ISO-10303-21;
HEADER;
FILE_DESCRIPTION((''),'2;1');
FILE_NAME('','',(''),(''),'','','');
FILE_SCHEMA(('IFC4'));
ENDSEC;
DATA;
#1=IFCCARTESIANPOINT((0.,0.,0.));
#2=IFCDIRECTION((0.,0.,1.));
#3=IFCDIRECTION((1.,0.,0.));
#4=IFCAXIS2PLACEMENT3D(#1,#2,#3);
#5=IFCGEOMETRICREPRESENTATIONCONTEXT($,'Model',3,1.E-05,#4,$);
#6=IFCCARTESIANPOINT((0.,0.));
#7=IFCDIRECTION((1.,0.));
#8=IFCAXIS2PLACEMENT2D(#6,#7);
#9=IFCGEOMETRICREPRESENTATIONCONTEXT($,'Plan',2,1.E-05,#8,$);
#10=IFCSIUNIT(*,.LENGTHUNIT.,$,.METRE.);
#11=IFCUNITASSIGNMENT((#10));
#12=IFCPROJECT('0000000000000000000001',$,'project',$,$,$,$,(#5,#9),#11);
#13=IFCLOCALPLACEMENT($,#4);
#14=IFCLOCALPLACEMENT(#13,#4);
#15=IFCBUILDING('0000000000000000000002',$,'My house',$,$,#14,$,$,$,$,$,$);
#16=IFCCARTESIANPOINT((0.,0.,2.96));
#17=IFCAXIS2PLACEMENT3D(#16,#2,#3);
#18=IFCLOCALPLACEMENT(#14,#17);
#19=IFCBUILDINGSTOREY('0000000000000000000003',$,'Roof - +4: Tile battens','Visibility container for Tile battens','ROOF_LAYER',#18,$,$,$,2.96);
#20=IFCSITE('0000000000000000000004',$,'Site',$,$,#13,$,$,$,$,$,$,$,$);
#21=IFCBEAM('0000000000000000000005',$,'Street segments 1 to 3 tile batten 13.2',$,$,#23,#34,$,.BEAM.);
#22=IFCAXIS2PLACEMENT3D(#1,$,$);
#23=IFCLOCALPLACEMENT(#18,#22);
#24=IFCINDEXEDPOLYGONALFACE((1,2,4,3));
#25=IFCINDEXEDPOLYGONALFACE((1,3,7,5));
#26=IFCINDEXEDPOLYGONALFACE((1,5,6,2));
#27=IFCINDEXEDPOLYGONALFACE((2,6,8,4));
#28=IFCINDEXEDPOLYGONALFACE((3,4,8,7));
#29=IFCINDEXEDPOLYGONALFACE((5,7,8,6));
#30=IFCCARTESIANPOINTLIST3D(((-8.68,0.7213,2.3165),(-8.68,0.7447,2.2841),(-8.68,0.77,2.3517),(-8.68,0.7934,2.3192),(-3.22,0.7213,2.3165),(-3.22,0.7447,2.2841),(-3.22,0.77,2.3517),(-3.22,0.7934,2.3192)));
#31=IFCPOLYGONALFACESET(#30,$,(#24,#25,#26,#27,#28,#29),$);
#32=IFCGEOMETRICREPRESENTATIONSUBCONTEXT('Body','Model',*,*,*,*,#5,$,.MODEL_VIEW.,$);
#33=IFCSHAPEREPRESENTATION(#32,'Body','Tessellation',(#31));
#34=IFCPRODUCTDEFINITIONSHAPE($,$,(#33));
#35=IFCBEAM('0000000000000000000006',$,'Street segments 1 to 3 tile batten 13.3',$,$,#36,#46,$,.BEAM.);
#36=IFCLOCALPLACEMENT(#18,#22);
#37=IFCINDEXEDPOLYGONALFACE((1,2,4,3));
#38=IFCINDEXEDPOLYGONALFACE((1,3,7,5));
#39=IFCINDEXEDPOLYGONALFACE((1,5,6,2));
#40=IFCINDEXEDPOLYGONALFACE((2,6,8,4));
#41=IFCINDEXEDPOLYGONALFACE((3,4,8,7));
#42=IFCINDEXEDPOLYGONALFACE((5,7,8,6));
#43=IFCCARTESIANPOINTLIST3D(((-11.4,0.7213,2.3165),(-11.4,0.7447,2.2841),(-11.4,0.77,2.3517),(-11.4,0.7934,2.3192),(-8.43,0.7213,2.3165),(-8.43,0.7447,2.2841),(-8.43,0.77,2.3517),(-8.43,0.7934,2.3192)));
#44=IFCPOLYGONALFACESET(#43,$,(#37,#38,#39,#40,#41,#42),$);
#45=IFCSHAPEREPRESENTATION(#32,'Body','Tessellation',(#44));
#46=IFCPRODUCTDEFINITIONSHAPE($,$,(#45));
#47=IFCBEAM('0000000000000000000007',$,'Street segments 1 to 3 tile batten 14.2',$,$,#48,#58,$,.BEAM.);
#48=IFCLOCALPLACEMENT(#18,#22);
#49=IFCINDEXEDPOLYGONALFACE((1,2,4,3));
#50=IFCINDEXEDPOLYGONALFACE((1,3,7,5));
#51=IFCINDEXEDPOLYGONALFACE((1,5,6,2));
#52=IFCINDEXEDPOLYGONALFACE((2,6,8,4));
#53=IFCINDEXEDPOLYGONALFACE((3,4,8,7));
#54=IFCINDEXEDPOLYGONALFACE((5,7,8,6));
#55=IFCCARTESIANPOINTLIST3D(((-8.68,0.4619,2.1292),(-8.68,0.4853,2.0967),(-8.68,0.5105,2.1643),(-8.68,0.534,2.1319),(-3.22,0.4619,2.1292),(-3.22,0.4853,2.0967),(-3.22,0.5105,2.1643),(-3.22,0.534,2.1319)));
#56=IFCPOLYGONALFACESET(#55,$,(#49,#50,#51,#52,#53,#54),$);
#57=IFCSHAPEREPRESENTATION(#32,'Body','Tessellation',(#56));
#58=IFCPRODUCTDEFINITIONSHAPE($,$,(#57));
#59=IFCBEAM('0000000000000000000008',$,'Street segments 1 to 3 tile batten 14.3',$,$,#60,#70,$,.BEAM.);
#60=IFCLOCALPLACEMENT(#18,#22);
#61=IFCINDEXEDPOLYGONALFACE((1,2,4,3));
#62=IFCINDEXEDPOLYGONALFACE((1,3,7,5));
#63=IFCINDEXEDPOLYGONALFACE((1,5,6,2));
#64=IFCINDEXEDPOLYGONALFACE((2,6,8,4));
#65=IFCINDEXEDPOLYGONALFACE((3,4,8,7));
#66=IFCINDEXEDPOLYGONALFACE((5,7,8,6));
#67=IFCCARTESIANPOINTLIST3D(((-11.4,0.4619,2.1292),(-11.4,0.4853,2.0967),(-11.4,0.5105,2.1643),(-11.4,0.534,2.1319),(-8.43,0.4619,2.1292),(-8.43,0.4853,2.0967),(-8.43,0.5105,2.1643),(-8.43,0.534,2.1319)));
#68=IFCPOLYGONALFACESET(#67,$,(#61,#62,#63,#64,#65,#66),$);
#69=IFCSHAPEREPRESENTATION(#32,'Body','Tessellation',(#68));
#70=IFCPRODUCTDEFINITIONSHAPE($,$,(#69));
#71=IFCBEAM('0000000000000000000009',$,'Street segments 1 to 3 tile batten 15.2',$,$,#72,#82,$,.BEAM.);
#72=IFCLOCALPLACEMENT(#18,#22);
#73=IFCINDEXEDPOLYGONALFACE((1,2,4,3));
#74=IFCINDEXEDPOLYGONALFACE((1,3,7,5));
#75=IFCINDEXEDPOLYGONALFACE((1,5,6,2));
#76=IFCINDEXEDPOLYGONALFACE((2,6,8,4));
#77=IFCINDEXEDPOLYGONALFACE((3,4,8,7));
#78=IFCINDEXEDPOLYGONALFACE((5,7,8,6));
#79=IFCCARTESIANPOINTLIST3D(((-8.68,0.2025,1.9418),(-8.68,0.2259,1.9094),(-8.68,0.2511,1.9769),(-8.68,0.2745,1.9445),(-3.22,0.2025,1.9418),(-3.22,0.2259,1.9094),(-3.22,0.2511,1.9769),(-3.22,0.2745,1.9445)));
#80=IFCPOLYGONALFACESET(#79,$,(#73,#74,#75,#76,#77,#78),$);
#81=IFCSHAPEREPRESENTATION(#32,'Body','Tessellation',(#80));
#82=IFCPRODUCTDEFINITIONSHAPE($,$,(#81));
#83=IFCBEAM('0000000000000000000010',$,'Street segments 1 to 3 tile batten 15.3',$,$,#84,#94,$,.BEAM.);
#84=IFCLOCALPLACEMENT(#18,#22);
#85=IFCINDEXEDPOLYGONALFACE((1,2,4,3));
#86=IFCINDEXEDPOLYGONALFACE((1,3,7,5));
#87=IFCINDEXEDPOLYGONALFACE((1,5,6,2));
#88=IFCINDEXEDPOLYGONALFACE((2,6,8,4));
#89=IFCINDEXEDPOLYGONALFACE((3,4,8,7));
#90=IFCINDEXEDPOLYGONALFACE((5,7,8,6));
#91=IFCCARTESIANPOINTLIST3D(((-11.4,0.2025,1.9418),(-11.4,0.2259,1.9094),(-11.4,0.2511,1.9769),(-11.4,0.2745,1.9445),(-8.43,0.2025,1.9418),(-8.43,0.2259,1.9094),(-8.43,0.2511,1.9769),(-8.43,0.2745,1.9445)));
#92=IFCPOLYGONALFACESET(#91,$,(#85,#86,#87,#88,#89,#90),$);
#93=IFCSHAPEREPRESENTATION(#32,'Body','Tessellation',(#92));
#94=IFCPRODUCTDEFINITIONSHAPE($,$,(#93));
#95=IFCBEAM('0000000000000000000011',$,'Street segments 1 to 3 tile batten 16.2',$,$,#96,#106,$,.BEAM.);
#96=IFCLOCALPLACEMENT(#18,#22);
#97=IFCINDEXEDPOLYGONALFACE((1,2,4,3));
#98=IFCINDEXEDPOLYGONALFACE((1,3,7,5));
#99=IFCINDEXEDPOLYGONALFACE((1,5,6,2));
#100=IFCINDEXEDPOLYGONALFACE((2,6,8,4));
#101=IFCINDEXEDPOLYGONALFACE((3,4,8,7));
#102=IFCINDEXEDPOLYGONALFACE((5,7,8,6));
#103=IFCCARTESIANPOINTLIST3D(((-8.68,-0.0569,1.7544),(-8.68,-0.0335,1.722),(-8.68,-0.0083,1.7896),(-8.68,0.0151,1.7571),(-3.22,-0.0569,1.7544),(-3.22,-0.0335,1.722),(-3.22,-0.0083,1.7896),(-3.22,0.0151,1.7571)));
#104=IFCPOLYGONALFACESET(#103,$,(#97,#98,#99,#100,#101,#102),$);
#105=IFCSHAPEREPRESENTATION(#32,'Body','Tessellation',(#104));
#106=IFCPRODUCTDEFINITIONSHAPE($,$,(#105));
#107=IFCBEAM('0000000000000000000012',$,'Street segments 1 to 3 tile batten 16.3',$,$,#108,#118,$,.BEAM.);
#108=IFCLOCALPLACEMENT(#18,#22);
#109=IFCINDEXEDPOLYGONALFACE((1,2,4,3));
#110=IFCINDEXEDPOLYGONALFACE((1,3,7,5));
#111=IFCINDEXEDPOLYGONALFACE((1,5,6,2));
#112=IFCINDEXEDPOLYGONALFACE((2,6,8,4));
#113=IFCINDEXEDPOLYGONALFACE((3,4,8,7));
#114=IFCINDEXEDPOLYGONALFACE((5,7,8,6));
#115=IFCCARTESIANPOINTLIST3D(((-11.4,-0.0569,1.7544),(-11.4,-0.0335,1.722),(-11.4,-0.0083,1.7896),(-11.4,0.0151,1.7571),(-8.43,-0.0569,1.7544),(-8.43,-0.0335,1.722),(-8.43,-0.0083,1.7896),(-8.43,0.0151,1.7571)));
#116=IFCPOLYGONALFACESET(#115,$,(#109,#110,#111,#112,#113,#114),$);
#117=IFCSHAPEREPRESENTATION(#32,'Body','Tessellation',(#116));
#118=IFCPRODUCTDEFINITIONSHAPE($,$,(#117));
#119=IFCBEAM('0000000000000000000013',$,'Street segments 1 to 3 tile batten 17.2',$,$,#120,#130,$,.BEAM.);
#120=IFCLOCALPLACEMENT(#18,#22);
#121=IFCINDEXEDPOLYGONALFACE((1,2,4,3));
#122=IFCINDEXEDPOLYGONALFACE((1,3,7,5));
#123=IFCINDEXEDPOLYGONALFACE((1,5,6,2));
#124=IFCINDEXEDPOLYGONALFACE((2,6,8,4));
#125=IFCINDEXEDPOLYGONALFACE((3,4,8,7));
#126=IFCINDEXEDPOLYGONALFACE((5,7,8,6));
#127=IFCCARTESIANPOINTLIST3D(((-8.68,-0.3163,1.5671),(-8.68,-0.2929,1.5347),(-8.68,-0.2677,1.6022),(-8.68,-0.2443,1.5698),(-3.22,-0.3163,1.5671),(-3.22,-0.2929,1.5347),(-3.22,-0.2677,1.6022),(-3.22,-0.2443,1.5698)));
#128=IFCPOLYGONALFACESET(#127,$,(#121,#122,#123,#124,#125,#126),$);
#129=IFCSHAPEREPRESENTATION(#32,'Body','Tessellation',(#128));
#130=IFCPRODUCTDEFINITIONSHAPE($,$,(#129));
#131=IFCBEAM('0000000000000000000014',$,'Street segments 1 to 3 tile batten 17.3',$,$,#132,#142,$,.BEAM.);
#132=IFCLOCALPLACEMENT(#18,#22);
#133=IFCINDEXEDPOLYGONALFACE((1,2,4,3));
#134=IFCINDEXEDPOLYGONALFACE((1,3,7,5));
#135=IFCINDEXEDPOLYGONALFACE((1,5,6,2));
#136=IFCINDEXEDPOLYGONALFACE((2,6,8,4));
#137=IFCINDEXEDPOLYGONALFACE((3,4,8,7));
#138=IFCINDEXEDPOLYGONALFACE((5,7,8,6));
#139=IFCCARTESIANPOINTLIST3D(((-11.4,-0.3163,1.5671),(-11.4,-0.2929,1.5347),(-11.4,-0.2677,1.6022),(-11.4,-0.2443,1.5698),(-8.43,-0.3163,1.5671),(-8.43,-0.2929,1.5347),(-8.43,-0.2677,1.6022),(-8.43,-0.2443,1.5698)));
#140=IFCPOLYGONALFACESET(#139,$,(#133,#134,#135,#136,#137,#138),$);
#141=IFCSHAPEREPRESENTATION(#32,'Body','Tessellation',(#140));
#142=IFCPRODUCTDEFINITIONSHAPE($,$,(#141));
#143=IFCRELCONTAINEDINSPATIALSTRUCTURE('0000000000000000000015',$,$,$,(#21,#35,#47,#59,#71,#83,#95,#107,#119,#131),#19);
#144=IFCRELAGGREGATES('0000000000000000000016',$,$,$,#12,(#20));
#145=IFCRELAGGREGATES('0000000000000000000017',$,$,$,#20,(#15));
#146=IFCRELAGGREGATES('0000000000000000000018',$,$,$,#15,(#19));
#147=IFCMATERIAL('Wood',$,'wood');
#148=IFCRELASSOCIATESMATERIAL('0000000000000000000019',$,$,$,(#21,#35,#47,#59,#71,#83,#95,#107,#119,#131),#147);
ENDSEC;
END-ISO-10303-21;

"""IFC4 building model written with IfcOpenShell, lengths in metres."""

from ifc_helpers import new_model, si_unit, frame, origin_with_axes, origin_2d_with_axis, place, context, subcontext, project, spatial, rectangle, extrude, clip, halfspace, source, transform, mapped, material, element, save


model = new_model("IFC4")

# Units and contexts
model_context = context("Model", 3, precision=1e-05, world=origin_with_axes())
plan_context = context("Plan", 2, precision=1e-05, world=origin_2d_with_axis())
body_context = subcontext(model_context, "Body", "Model", "MODEL_VIEW")
ifc_project = project(units=[si_unit("LENGTHUNIT", "METRE")], contexts=[model_context, plan_context])

# Site, building, storey
site_placement = place(None, origin_with_axes())
site = spatial("IfcSite", under=ifc_project, at=site_placement, Name="Site")
building_placement = place(site_placement, origin_with_axes())
building = spatial("IfcBuilding", under=site, at=building_placement, Name="My house")
storey_placement = place(building_placement, frame((0.0, 0.0, 2.96), z_axis=(0.0, 0.0, 1.0), x_axis=(1.0, 0.0, 0.0)))
storey = spatial("IfcBuildingStorey", under=building, at=storey_placement, Name="Roof - +4: Tile battens", Description="Visibility container for Tile battens", ObjectType="ROOF_LAYER", Elevation=2.96)

# Beams
ifc_material = material(Name="Wood", Category="wood")
shared_shape_1 = source(origin_with_axes(), body_context, "Body", "Clipping", [
    clip(clip(extrude(rectangle(XDim=0.06, YDim=0.04), frame((0.0, 0.0, 0.0), z_axis=(1.0, 0.0, 0.0), x_axis=(0.0, 1.0, 0.0)), (0.0, 0.0, 1.0), 5.46), halfspace(frame((-3.22, -0.4616, -6.1772), z_axis=(0.0, 0.810664, -0.585512), x_axis=(1.0, 0.0, 0.0)), False)), halfspace(frame((-3.22, -4.3122, -3.396), z_axis=(0.0, -0.810664, 0.585512), x_axis=(-1.0, 0.0, 0.0)), False)),
])
beam_1_placement = place(storey_placement, frame((-3.22, 0.7573, 2.3179), z_axis=(0.0, -0.585512, 0.810664), x_axis=(1.0, 0.0, 0.0)))
element("IfcBeam", 1, at=beam_1_placement, inside=storey, material=ifc_material, Name="Street segments 1 to 3 tile batten 13.2", PredefinedType="BEAM", context=body_context, shape_type="MappedRepresentation", body=[
    mapped(shared_shape_1, transform((0.0, 0.0, 0.0), x_axis=(-1.0, 0.0, 0.0), y_axis=(0.0, 1.0, 0.0), z_axis=(0.0, 0.0, 1.0), scale=1.0)),
])
shared_shape_2 = source(origin_with_axes(), body_context, "Body", "Clipping", [
    clip(clip(extrude(rectangle(XDim=0.06, YDim=0.04), frame((0.0, 0.0, 0.0), z_axis=(1.0, 0.0, 0.0), x_axis=(0.0, 1.0, 0.0)), (0.0, 0.0, 1.0), 2.97), halfspace(frame((-8.43, -0.4616, -6.1772), z_axis=(0.0, 0.810664, -0.585512), x_axis=(1.0, 0.0, 0.0)), False)), halfspace(frame((-8.43, -4.3122, -3.396), z_axis=(0.0, -0.810664, 0.585512), x_axis=(-1.0, 0.0, 0.0)), False)),
])
beam_2_placement = place(storey_placement, frame((-8.43, 0.7573, 2.3179), z_axis=(0.0, -0.585512, 0.810664), x_axis=(1.0, 0.0, 0.0)))
element("IfcBeam", 2, at=beam_2_placement, inside=storey, material=ifc_material, Name="Street segments 1 to 3 tile batten 13.3", PredefinedType="BEAM", context=body_context, shape_type="MappedRepresentation", body=[
    mapped(shared_shape_2, transform((0.0, 0.0, 0.0), x_axis=(-1.0, 0.0, 0.0), y_axis=(0.0, 1.0, 0.0), z_axis=(0.0, 0.0, 1.0), scale=1.0)),
])
shared_shape_3 = source(origin_with_axes(), body_context, "Body", "Clipping", [
    clip(clip(extrude(rectangle(XDim=0.06, YDim=0.04), frame((0.0, 0.0, 0.0), z_axis=(1.0, 0.0, 0.0), x_axis=(0.0, 1.0, 0.0)), (0.0, 0.0, 1.0), 5.46), halfspace(frame((-3.22, -0.1416, -6.1772), z_axis=(0.0, 0.810664, -0.585512), x_axis=(1.0, 0.0, 0.0)), False)), halfspace(frame((-3.22, -3.9922, -3.396), z_axis=(0.0, -0.810664, 0.585512), x_axis=(-1.0, 0.0, 0.0)), False)),
])
beam_3_placement = place(storey_placement, frame((-3.22, 0.4979, 2.1305), z_axis=(0.0, -0.585512, 0.810664), x_axis=(1.0, 0.0, 0.0)))
element("IfcBeam", 3, at=beam_3_placement, inside=storey, material=ifc_material, Name="Street segments 1 to 3 tile batten 14.2", PredefinedType="BEAM", context=body_context, shape_type="MappedRepresentation", body=[
    mapped(shared_shape_3, transform((0.0, 0.0, 0.0), x_axis=(-1.0, 0.0, 0.0), y_axis=(0.0, 1.0, 0.0), z_axis=(0.0, 0.0, 1.0), scale=1.0)),
])
shared_shape_4 = source(origin_with_axes(), body_context, "Body", "Clipping", [
    clip(clip(extrude(rectangle(XDim=0.06, YDim=0.04), frame((0.0, 0.0, 0.0), z_axis=(1.0, 0.0, 0.0), x_axis=(0.0, 1.0, 0.0)), (0.0, 0.0, 1.0), 2.97), halfspace(frame((-8.43, -0.1416, -6.1772), z_axis=(0.0, 0.810664, -0.585512), x_axis=(1.0, 0.0, 0.0)), False)), halfspace(frame((-8.43, -3.9922, -3.396), z_axis=(0.0, -0.810664, 0.585512), x_axis=(-1.0, 0.0, 0.0)), False)),
])
beam_4_placement = place(storey_placement, frame((-8.43, 0.4979, 2.1305), z_axis=(0.0, -0.585512, 0.810664), x_axis=(1.0, 0.0, 0.0)))
element("IfcBeam", 4, at=beam_4_placement, inside=storey, material=ifc_material, Name="Street segments 1 to 3 tile batten 14.3", PredefinedType="BEAM", context=body_context, shape_type="MappedRepresentation", body=[
    mapped(shared_shape_4, transform((0.0, 0.0, 0.0), x_axis=(-1.0, 0.0, 0.0), y_axis=(0.0, 1.0, 0.0), z_axis=(0.0, 0.0, 1.0), scale=1.0)),
])
shared_shape_5 = source(origin_with_axes(), body_context, "Body", "Clipping", [
    clip(clip(extrude(rectangle(XDim=0.06, YDim=0.04), frame((0.0, 0.0, 0.0), z_axis=(1.0, 0.0, 0.0), x_axis=(0.0, 1.0, 0.0)), (0.0, 0.0, 1.0), 5.46), halfspace(frame((-3.22, 0.1784, -6.1772), z_axis=(0.0, 0.810664, -0.585512), x_axis=(1.0, 0.0, 0.0)), False)), halfspace(frame((-3.22, -3.6722, -3.396), z_axis=(0.0, -0.810664, 0.585512), x_axis=(-1.0, 0.0, 0.0)), False)),
])
beam_5_placement = place(storey_placement, frame((-3.22, 0.2385, 1.9432), z_axis=(0.0, -0.585512, 0.810664), x_axis=(1.0, 0.0, 0.0)))
element("IfcBeam", 5, at=beam_5_placement, inside=storey, material=ifc_material, Name="Street segments 1 to 3 tile batten 15.2", PredefinedType="BEAM", context=body_context, shape_type="MappedRepresentation", body=[
    mapped(shared_shape_5, transform((0.0, 0.0, 0.0), x_axis=(-1.0, 0.0, 0.0), y_axis=(0.0, 1.0, 0.0), z_axis=(0.0, 0.0, 1.0), scale=1.0)),
])
shared_shape_6 = source(origin_with_axes(), body_context, "Body", "Clipping", [
    clip(clip(extrude(rectangle(XDim=0.06, YDim=0.04), frame((0.0, 0.0, 0.0), z_axis=(1.0, 0.0, 0.0), x_axis=(0.0, 1.0, 0.0)), (0.0, 0.0, 1.0), 2.97), halfspace(frame((-8.43, 0.1784, -6.1772), z_axis=(0.0, 0.810664, -0.585512), x_axis=(1.0, 0.0, 0.0)), False)), halfspace(frame((-8.43, -3.6722, -3.396), z_axis=(0.0, -0.810664, 0.585512), x_axis=(-1.0, 0.0, 0.0)), False)),
])
beam_6_placement = place(storey_placement, frame((-8.43, 0.2385, 1.9432), z_axis=(0.0, -0.585512, 0.810664), x_axis=(1.0, 0.0, 0.0)))
element("IfcBeam", 6, at=beam_6_placement, inside=storey, material=ifc_material, Name="Street segments 1 to 3 tile batten 15.3", PredefinedType="BEAM", context=body_context, shape_type="MappedRepresentation", body=[
    mapped(shared_shape_6, transform((0.0, 0.0, 0.0), x_axis=(-1.0, 0.0, 0.0), y_axis=(0.0, 1.0, 0.0), z_axis=(0.0, 0.0, 1.0), scale=1.0)),
])
shared_shape_7 = source(origin_with_axes(), body_context, "Body", "Clipping", [
    clip(clip(extrude(rectangle(XDim=0.06, YDim=0.04), frame((0.0, 0.0, 0.0), z_axis=(1.0, 0.0, 0.0), x_axis=(0.0, 1.0, 0.0)), (0.0, 0.0, 1.0), 5.46), halfspace(frame((-3.22, 0.4984, -6.1772), z_axis=(0.0, 0.810664, -0.585512), x_axis=(1.0, 0.0, 0.0)), False)), halfspace(frame((-3.22, -3.3522, -3.396), z_axis=(0.0, -0.810664, 0.585512), x_axis=(-1.0, 0.0, 0.0)), False)),
])
beam_7_placement = place(storey_placement, frame((-3.22, -0.0209, 1.7558), z_axis=(0.0, -0.585512, 0.810664), x_axis=(1.0, 0.0, 0.0)))
element("IfcBeam", 7, at=beam_7_placement, inside=storey, material=ifc_material, Name="Street segments 1 to 3 tile batten 16.2", PredefinedType="BEAM", context=body_context, shape_type="MappedRepresentation", body=[
    mapped(shared_shape_7, transform((0.0, 0.0, 0.0), x_axis=(-1.0, 0.0, 0.0), y_axis=(0.0, 1.0, 0.0), z_axis=(0.0, 0.0, 1.0), scale=1.0)),
])
shared_shape_8 = source(origin_with_axes(), body_context, "Body", "Clipping", [
    clip(clip(extrude(rectangle(XDim=0.06, YDim=0.04), frame((0.0, 0.0, 0.0), z_axis=(1.0, 0.0, 0.0), x_axis=(0.0, 1.0, 0.0)), (0.0, 0.0, 1.0), 2.97), halfspace(frame((-8.43, 0.4984, -6.1772), z_axis=(0.0, 0.810664, -0.585512), x_axis=(1.0, 0.0, 0.0)), False)), halfspace(frame((-8.43, -3.3522, -3.396), z_axis=(0.0, -0.810664, 0.585512), x_axis=(-1.0, 0.0, 0.0)), False)),
])
beam_8_placement = place(storey_placement, frame((-8.43, -0.0209, 1.7558), z_axis=(0.0, -0.585512, 0.810664), x_axis=(1.0, 0.0, 0.0)))
element("IfcBeam", 8, at=beam_8_placement, inside=storey, material=ifc_material, Name="Street segments 1 to 3 tile batten 16.3", PredefinedType="BEAM", context=body_context, shape_type="MappedRepresentation", body=[
    mapped(shared_shape_8, transform((0.0, 0.0, 0.0), x_axis=(-1.0, 0.0, 0.0), y_axis=(0.0, 1.0, 0.0), z_axis=(0.0, 0.0, 1.0), scale=1.0)),
])
shared_shape_9 = source(origin_with_axes(), body_context, "Body", "Clipping", [
    clip(clip(extrude(rectangle(XDim=0.06, YDim=0.04), frame((0.0, 0.0, 0.0), z_axis=(1.0, 0.0, 0.0), x_axis=(0.0, 1.0, 0.0)), (0.0, 0.0, 1.0), 5.46), halfspace(frame((-3.22, 0.8184, -6.1772), z_axis=(0.0, 0.810664, -0.585512), x_axis=(1.0, 0.0, 0.0)), False)), halfspace(frame((-3.22, -3.0322, -3.396), z_axis=(0.0, -0.810664, 0.585512), x_axis=(-1.0, 0.0, 0.0)), False)),
])
beam_9_placement = place(storey_placement, frame((-3.22, -0.2803, 1.5684), z_axis=(0.0, -0.585512, 0.810664), x_axis=(1.0, 0.0, 0.0)))
element("IfcBeam", 9, at=beam_9_placement, inside=storey, material=ifc_material, Name="Street segments 1 to 3 tile batten 17.2", PredefinedType="BEAM", context=body_context, shape_type="MappedRepresentation", body=[
    mapped(shared_shape_9, transform((0.0, 0.0, 0.0), x_axis=(-1.0, 0.0, 0.0), y_axis=(0.0, 1.0, 0.0), z_axis=(0.0, 0.0, 1.0), scale=1.0)),
])
shared_shape_10 = source(origin_with_axes(), body_context, "Body", "Clipping", [
    clip(clip(extrude(rectangle(XDim=0.06, YDim=0.04), frame((0.0, 0.0, 0.0), z_axis=(1.0, 0.0, 0.0), x_axis=(0.0, 1.0, 0.0)), (0.0, 0.0, 1.0), 2.97), halfspace(frame((-8.43, 0.8184, -6.1772), z_axis=(0.0, 0.810664, -0.585512), x_axis=(1.0, 0.0, 0.0)), False)), halfspace(frame((-8.43, -3.0322, -3.396), z_axis=(0.0, -0.810664, 0.585512), x_axis=(-1.0, 0.0, 0.0)), False)),
])
beam_10_placement = place(storey_placement, frame((-8.43, -0.2803, 1.5684), z_axis=(0.0, -0.585512, 0.810664), x_axis=(1.0, 0.0, 0.0)))
element("IfcBeam", 10, at=beam_10_placement, inside=storey, material=ifc_material, Name="Street segments 1 to 3 tile batten 17.3", PredefinedType="BEAM", context=body_context, shape_type="MappedRepresentation", body=[
    mapped(shared_shape_10, transform((0.0, 0.0, 0.0), x_axis=(-1.0, 0.0, 0.0), y_axis=(0.0, 1.0, 0.0), z_axis=(0.0, 0.0, 1.0), scale=1.0)),
])

save(model, "model.ifc")
